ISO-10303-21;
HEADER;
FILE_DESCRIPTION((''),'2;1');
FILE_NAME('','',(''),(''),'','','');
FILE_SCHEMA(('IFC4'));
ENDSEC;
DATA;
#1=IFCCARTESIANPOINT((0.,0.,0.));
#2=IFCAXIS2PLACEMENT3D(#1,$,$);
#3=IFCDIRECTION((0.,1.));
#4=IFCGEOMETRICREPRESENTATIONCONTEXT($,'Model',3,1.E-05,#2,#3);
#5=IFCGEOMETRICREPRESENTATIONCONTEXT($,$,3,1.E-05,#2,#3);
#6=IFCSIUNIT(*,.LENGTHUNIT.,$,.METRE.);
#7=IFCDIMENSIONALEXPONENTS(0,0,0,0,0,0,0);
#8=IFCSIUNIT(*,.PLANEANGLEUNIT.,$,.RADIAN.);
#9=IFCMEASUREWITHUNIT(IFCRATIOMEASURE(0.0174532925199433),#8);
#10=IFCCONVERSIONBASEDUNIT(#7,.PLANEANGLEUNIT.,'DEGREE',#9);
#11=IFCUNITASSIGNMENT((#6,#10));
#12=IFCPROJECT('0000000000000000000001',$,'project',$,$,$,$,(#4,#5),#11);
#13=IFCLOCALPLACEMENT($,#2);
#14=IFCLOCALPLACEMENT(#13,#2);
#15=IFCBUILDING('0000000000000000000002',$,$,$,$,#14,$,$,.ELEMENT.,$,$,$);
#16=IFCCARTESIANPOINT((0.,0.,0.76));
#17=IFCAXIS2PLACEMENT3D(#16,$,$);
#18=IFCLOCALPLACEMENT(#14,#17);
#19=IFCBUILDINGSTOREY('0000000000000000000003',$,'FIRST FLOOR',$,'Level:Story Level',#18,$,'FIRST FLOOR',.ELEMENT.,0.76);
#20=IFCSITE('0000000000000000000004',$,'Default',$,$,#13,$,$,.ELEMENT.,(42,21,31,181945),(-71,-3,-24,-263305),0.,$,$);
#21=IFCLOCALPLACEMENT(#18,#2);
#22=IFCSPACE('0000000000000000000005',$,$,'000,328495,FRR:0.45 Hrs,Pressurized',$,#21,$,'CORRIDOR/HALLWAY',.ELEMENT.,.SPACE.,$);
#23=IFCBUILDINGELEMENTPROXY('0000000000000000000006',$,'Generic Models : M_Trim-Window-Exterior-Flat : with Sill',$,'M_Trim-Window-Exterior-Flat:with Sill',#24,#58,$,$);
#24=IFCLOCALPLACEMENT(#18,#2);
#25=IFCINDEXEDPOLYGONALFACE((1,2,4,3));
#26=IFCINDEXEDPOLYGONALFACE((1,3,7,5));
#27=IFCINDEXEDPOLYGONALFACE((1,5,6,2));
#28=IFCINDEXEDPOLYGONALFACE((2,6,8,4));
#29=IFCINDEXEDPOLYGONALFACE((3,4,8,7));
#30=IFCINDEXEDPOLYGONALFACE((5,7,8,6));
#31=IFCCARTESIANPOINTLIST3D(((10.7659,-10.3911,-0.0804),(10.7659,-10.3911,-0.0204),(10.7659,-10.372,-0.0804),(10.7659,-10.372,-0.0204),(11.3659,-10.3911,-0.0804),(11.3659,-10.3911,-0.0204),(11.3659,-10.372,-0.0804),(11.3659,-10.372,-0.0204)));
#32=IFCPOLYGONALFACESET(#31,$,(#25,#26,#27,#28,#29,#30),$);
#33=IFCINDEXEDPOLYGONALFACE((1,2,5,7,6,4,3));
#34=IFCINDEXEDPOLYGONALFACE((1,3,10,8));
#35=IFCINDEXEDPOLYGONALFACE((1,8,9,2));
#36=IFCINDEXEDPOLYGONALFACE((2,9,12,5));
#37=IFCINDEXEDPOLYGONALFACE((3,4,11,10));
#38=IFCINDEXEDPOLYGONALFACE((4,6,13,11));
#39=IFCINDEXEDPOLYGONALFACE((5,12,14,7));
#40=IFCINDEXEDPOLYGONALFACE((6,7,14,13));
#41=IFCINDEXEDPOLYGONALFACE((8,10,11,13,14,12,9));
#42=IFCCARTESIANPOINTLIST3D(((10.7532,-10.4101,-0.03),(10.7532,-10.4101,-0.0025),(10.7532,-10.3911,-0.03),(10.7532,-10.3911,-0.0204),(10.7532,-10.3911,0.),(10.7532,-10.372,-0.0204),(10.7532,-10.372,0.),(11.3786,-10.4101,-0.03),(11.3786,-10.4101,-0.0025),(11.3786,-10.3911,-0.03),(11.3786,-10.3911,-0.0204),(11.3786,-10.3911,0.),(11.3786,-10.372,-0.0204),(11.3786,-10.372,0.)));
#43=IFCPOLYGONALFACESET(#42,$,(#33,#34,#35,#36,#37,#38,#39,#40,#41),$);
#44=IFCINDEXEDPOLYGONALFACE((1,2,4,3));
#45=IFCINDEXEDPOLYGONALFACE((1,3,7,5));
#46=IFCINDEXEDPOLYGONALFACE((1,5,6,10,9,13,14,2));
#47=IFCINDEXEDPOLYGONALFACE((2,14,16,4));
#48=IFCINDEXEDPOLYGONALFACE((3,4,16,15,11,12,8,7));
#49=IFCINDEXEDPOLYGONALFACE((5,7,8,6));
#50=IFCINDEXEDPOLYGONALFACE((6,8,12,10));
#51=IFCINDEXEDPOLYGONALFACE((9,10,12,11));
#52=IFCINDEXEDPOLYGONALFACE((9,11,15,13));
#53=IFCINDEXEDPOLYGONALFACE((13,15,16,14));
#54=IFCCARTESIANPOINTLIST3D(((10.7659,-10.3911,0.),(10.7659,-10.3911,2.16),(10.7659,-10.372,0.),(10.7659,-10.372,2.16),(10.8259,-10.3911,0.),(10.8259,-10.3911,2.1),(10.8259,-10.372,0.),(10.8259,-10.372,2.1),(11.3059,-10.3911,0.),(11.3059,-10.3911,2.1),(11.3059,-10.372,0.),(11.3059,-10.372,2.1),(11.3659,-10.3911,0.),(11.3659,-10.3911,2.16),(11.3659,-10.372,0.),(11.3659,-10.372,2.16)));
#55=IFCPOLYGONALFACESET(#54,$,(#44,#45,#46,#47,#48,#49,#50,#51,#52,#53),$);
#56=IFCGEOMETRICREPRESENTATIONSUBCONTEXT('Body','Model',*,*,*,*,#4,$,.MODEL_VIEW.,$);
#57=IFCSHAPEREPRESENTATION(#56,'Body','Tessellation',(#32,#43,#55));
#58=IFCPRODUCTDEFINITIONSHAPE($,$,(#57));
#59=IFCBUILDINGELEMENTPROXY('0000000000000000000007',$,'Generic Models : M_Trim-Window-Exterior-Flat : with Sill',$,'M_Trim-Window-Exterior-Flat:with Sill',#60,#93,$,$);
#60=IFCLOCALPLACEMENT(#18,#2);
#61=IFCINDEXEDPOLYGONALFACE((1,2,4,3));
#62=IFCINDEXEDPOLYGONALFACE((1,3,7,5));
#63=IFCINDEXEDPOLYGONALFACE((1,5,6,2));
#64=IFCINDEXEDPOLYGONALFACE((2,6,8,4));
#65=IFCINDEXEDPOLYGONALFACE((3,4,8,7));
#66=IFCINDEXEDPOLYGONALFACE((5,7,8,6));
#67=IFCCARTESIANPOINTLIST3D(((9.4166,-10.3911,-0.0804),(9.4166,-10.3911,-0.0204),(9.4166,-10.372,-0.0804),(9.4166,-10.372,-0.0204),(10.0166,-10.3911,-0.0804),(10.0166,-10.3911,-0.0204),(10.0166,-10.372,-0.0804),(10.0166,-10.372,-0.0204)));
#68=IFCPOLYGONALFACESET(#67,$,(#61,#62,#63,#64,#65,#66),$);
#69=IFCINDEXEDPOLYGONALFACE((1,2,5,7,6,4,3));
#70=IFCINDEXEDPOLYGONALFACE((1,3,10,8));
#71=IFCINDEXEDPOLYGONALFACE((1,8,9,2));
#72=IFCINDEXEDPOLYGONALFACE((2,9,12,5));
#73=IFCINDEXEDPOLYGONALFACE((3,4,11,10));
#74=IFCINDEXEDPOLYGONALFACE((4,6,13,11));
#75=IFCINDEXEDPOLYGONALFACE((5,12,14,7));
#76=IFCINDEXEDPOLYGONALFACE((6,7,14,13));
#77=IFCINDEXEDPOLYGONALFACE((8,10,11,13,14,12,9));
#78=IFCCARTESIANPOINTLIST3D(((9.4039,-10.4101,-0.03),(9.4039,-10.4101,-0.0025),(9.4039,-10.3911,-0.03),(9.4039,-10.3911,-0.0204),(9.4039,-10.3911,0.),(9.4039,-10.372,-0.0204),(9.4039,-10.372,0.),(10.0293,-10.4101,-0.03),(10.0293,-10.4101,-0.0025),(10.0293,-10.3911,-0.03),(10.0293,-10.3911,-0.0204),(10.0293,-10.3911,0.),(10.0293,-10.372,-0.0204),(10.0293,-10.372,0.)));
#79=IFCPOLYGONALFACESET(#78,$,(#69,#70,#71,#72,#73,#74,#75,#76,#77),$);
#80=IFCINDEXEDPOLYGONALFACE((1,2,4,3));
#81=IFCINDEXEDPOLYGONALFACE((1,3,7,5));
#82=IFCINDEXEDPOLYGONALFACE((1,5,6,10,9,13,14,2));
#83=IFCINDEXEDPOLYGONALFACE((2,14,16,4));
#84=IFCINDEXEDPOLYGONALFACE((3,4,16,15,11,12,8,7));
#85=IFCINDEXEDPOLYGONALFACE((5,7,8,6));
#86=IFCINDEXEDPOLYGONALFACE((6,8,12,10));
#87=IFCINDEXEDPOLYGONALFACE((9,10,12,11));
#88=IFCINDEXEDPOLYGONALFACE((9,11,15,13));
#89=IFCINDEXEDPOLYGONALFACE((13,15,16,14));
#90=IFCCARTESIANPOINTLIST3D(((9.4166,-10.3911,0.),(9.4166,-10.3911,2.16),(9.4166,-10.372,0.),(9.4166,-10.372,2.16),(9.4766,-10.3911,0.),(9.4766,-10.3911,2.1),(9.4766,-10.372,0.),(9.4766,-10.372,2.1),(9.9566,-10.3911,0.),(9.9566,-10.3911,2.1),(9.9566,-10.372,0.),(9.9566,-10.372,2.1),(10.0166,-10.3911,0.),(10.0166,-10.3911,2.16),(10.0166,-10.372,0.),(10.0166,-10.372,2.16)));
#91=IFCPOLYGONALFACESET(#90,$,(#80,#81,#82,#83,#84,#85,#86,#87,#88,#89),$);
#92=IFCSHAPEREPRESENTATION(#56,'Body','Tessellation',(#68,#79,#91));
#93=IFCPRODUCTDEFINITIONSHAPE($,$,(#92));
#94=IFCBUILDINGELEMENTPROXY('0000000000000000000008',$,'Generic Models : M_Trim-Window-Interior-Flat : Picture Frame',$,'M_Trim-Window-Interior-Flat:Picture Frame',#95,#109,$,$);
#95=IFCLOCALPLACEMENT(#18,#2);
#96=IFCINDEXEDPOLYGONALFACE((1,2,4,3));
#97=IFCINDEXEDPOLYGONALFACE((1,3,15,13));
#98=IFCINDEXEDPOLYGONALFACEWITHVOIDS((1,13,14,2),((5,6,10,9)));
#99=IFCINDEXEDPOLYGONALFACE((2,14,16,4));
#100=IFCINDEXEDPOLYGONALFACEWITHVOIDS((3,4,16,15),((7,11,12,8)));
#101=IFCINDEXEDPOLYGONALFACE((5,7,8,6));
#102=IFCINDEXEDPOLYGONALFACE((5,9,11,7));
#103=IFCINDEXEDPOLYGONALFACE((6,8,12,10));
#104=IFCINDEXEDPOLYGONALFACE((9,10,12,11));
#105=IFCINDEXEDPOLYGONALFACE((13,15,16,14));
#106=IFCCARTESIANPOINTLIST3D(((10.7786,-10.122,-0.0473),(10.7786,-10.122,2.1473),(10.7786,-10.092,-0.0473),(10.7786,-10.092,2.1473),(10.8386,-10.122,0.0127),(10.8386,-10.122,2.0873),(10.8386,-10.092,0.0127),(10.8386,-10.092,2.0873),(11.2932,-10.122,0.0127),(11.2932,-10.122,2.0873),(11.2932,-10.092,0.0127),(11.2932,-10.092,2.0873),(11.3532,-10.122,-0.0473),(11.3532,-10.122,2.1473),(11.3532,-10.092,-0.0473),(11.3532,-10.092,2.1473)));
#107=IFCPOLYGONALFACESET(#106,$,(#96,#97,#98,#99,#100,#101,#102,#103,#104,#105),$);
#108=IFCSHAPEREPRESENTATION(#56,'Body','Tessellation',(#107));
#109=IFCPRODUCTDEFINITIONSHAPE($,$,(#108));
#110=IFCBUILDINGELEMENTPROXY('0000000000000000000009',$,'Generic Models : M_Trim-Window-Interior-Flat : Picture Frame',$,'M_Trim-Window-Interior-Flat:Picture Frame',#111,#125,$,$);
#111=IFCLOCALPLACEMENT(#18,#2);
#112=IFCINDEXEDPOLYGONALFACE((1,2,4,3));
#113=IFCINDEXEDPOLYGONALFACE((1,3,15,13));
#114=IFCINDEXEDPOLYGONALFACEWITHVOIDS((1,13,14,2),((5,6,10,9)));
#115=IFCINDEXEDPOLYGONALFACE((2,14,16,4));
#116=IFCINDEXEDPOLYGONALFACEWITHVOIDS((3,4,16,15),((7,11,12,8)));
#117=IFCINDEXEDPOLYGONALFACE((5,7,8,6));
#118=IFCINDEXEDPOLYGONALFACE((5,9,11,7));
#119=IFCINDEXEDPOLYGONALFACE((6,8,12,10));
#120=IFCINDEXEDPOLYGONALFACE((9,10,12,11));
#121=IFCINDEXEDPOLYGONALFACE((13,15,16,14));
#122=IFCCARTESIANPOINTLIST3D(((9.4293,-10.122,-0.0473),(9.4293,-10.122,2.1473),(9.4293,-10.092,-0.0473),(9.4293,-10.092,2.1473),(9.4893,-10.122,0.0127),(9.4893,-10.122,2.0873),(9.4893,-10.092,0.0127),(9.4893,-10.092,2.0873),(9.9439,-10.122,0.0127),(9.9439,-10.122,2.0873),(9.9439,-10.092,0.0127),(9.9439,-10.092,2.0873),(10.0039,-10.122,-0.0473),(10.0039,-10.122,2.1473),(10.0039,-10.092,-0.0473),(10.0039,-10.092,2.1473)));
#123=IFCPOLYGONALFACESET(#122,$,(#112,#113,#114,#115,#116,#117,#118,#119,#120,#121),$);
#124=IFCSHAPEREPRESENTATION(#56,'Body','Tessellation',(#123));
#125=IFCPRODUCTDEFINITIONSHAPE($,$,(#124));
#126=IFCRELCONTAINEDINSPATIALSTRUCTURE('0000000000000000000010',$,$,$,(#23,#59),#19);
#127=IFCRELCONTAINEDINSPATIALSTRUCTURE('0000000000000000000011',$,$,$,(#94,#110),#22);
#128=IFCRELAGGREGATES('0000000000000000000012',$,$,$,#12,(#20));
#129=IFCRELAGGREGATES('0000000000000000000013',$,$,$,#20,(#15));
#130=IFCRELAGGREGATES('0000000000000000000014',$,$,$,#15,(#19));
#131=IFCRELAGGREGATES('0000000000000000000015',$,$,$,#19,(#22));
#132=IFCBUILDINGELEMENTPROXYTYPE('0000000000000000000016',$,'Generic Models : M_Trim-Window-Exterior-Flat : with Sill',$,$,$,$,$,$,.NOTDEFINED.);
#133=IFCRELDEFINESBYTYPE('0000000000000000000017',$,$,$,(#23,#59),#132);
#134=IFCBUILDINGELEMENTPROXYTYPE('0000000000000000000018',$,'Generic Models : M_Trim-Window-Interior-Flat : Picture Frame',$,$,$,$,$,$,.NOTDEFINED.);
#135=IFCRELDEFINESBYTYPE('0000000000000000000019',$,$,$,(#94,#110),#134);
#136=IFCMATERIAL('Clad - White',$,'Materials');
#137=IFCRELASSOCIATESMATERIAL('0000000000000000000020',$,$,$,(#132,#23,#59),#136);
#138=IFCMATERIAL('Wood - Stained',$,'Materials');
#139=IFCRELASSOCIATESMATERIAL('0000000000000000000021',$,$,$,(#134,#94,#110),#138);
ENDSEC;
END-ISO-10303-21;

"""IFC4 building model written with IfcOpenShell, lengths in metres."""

from ifc_helpers import new_model, entity, si_unit, converted_unit, direction, frame, origin, origin_2d_with_axis, place, context, subcontext, project, spatial, polyline, rectangle, outline, extrude, source, transform, mapped, material, type_object, type_shapes, element, save


model = new_model("IFC4")

# Units and contexts
model_context = context("Model", 3, precision=1e-05, world=origin(), true_north=direction((0.0, 1.0)))
context_of_model = context(None, 3, precision=1e-05, world=origin(), true_north=direction((0.0, 1.0)))
body_context = subcontext(model_context, "Body", "Model", "MODEL_VIEW")
ifc_project = project(units=[si_unit("LENGTHUNIT", "METRE"), converted_unit("PLANEANGLEUNIT", "DEGREE", entity("IfcRatioMeasure", 0.0174532925199433), si_unit("PLANEANGLEUNIT", "RADIAN"), dimensions=[0, 0, 0, 0, 0, 0, 0])], contexts=[model_context, context_of_model])

# Site, building, storey
site_placement = place(None, origin())
site = spatial("IfcSite", under=ifc_project, at=site_placement, Name="Default", CompositionType="ELEMENT", RefLatitude=(42, 21, 31, 181945), RefLongitude=(-71, -3, -24, -263305), RefElevation=0.0)
building_placement = place(site_placement, origin())
building = spatial("IfcBuilding", under=site, at=building_placement, CompositionType="ELEMENT")
storey_placement = place(building_placement, frame((0.0, 0.0, 0.76)))
storey = spatial("IfcBuildingStorey", under=building, at=storey_placement, Name="FIRST FLOOR", ObjectType="Level:Story Level", LongName="FIRST FLOOR", CompositionType="ELEMENT", Elevation=0.76)

# Building element proxies
ifc_material_1 = material(Name="Clad - White", Category="Materials")
ifc_material_2 = material(Name="Wood - Stained", Category="Materials")
building_element_proxy_type_1 = type_object("IfcBuildingElementProxyType", Name="Generic Models : M_Trim-Window-Exterior-Flat : with Sill", PredefinedType="NOTDEFINED", material=ifc_material_1)
shared_shape_1 = source(origin(), body_context, "Body", "SweptSolid", [
    extrude(rectangle(XDim=0.6, YDim=0.06, at=origin_2d_with_axis()), frame((0.0, -2.1504, 0.0), z_axis=(0.0, 0.0, 1.0), x_axis=(-1.0, 0.0, 0.0)), (0.0, 0.0, 1.0), 0.0191),
    extrude(outline(polyline([(-0.019, -0.0152), (0.0, -0.0152), (0.0, -0.0057), (0.019, -0.0057), (0.019, 0.0148), (0.0, 0.0148), (-0.019, 0.0123), (-0.019, -0.0152)])), frame((-0.3127, -2.1148, 0.019), z_axis=(1.0, 0.0, 0.0), x_axis=(0.0, 0.0, -1.0)), (0.0, 0.0, 1.0), 0.6254),
    extrude(outline(polyline([(-1.095, -0.3), (1.065, -0.3), (1.065, -0.24), (-1.035, -0.24), (-1.035, 0.24), (1.065, 0.24), (1.065, 0.3), (-1.095, 0.3), (-1.095, -0.3)])), frame((0.0, -1.035, 0.0), z_axis=(0.0, 0.0, 1.0), x_axis=(0.0, -1.0, 0.0)), (0.0, 0.0, 1.0), 0.0191),
])
type_shapes(building_element_proxy_type_1, [shared_shape_1])
for number, where, z_axis, x_axis, name in (
    (1, (11.0659, -10.372, 2.1), (0.0, -1.0, 0.0), (1.0, 0.0, 0.0), "Generic Models : M_Trim-Window-Exterior-Flat : with Sill"),
    (2, (9.7166, -10.372, 2.1), (0.0, -1.0, 0.0), (1.0, 0.0, 0.0), "Generic Models : M_Trim-Window-Exterior-Flat : with Sill"),
):
    element("IfcBuildingElementProxy", number, at=place(storey_placement, frame(where, z_axis=z_axis, x_axis=x_axis)), inside=storey, type_object=building_element_proxy_type_1, material=ifc_material_1, Name=name, ObjectType="M_Trim-Window-Exterior-Flat:with Sill", context=body_context, shape_type="MappedRepresentation", body=[
        mapped(shared_shape_1, transform((0.0, 0.0, 0.0), scale=1.0)),
    ])

# Shared definitions
space_placement = place(storey_placement, origin())
space = spatial("IfcSpace", under=storey, at=space_placement, Description="000,328495,FRR:0.45 Hrs,Pressurized", LongName="CORRIDOR/HALLWAY", CompositionType="ELEMENT", PredefinedType="SPACE")

# Building element proxies
building_element_proxy_type_2 = type_object("IfcBuildingElementProxyType", Name="Generic Models : M_Trim-Window-Interior-Flat : Picture Frame", PredefinedType="NOTDEFINED", material=ifc_material_2)
shared_shape_2 = source(origin(), body_context, "Body", "SweptSolid", [
    extrude(outline(polyline([(-0.2873, -1.0973), (0.2873, -1.0973), (0.2873, 1.0973), (-0.2873, 1.0973), (-0.2873, -1.0973)]), holes=[polyline([(-0.2273, -1.0373), (-0.2273, 1.0373), (0.2273, 1.0373), (0.2273, -1.0373), (-0.2273, -1.0373)])]), frame((0.0, -1.05, 0.0), z_axis=(0.0, 0.0, 1.0), x_axis=(-1.0, 0.0, 0.0)), (0.0, 0.0, 1.0), 0.03),
])
type_shapes(building_element_proxy_type_2, [shared_shape_2])
for number, where, z_axis, x_axis, name in (
    (3, (11.0659, -10.122, 2.1), (0.0, 1.0, 0.0), (-1.0, 0.0, 0.0), "Generic Models : M_Trim-Window-Interior-Flat : Picture Frame"),
    (4, (9.7166, -10.122, 2.1), (0.0, 1.0, 0.0), (-1.0, 0.0, 0.0), "Generic Models : M_Trim-Window-Interior-Flat : Picture Frame"),
):
    element("IfcBuildingElementProxy", number, at=place(space_placement, frame(where, z_axis=z_axis, x_axis=x_axis)), inside=space, type_object=building_element_proxy_type_2, material=ifc_material_2, Name=name, ObjectType="M_Trim-Window-Interior-Flat:Picture Frame", context=body_context, shape_type="MappedRepresentation", body=[
        mapped(shared_shape_2, transform((0.0, 0.0, 0.0), scale=1.0)),
    ])

save(model, "model.ifc")
